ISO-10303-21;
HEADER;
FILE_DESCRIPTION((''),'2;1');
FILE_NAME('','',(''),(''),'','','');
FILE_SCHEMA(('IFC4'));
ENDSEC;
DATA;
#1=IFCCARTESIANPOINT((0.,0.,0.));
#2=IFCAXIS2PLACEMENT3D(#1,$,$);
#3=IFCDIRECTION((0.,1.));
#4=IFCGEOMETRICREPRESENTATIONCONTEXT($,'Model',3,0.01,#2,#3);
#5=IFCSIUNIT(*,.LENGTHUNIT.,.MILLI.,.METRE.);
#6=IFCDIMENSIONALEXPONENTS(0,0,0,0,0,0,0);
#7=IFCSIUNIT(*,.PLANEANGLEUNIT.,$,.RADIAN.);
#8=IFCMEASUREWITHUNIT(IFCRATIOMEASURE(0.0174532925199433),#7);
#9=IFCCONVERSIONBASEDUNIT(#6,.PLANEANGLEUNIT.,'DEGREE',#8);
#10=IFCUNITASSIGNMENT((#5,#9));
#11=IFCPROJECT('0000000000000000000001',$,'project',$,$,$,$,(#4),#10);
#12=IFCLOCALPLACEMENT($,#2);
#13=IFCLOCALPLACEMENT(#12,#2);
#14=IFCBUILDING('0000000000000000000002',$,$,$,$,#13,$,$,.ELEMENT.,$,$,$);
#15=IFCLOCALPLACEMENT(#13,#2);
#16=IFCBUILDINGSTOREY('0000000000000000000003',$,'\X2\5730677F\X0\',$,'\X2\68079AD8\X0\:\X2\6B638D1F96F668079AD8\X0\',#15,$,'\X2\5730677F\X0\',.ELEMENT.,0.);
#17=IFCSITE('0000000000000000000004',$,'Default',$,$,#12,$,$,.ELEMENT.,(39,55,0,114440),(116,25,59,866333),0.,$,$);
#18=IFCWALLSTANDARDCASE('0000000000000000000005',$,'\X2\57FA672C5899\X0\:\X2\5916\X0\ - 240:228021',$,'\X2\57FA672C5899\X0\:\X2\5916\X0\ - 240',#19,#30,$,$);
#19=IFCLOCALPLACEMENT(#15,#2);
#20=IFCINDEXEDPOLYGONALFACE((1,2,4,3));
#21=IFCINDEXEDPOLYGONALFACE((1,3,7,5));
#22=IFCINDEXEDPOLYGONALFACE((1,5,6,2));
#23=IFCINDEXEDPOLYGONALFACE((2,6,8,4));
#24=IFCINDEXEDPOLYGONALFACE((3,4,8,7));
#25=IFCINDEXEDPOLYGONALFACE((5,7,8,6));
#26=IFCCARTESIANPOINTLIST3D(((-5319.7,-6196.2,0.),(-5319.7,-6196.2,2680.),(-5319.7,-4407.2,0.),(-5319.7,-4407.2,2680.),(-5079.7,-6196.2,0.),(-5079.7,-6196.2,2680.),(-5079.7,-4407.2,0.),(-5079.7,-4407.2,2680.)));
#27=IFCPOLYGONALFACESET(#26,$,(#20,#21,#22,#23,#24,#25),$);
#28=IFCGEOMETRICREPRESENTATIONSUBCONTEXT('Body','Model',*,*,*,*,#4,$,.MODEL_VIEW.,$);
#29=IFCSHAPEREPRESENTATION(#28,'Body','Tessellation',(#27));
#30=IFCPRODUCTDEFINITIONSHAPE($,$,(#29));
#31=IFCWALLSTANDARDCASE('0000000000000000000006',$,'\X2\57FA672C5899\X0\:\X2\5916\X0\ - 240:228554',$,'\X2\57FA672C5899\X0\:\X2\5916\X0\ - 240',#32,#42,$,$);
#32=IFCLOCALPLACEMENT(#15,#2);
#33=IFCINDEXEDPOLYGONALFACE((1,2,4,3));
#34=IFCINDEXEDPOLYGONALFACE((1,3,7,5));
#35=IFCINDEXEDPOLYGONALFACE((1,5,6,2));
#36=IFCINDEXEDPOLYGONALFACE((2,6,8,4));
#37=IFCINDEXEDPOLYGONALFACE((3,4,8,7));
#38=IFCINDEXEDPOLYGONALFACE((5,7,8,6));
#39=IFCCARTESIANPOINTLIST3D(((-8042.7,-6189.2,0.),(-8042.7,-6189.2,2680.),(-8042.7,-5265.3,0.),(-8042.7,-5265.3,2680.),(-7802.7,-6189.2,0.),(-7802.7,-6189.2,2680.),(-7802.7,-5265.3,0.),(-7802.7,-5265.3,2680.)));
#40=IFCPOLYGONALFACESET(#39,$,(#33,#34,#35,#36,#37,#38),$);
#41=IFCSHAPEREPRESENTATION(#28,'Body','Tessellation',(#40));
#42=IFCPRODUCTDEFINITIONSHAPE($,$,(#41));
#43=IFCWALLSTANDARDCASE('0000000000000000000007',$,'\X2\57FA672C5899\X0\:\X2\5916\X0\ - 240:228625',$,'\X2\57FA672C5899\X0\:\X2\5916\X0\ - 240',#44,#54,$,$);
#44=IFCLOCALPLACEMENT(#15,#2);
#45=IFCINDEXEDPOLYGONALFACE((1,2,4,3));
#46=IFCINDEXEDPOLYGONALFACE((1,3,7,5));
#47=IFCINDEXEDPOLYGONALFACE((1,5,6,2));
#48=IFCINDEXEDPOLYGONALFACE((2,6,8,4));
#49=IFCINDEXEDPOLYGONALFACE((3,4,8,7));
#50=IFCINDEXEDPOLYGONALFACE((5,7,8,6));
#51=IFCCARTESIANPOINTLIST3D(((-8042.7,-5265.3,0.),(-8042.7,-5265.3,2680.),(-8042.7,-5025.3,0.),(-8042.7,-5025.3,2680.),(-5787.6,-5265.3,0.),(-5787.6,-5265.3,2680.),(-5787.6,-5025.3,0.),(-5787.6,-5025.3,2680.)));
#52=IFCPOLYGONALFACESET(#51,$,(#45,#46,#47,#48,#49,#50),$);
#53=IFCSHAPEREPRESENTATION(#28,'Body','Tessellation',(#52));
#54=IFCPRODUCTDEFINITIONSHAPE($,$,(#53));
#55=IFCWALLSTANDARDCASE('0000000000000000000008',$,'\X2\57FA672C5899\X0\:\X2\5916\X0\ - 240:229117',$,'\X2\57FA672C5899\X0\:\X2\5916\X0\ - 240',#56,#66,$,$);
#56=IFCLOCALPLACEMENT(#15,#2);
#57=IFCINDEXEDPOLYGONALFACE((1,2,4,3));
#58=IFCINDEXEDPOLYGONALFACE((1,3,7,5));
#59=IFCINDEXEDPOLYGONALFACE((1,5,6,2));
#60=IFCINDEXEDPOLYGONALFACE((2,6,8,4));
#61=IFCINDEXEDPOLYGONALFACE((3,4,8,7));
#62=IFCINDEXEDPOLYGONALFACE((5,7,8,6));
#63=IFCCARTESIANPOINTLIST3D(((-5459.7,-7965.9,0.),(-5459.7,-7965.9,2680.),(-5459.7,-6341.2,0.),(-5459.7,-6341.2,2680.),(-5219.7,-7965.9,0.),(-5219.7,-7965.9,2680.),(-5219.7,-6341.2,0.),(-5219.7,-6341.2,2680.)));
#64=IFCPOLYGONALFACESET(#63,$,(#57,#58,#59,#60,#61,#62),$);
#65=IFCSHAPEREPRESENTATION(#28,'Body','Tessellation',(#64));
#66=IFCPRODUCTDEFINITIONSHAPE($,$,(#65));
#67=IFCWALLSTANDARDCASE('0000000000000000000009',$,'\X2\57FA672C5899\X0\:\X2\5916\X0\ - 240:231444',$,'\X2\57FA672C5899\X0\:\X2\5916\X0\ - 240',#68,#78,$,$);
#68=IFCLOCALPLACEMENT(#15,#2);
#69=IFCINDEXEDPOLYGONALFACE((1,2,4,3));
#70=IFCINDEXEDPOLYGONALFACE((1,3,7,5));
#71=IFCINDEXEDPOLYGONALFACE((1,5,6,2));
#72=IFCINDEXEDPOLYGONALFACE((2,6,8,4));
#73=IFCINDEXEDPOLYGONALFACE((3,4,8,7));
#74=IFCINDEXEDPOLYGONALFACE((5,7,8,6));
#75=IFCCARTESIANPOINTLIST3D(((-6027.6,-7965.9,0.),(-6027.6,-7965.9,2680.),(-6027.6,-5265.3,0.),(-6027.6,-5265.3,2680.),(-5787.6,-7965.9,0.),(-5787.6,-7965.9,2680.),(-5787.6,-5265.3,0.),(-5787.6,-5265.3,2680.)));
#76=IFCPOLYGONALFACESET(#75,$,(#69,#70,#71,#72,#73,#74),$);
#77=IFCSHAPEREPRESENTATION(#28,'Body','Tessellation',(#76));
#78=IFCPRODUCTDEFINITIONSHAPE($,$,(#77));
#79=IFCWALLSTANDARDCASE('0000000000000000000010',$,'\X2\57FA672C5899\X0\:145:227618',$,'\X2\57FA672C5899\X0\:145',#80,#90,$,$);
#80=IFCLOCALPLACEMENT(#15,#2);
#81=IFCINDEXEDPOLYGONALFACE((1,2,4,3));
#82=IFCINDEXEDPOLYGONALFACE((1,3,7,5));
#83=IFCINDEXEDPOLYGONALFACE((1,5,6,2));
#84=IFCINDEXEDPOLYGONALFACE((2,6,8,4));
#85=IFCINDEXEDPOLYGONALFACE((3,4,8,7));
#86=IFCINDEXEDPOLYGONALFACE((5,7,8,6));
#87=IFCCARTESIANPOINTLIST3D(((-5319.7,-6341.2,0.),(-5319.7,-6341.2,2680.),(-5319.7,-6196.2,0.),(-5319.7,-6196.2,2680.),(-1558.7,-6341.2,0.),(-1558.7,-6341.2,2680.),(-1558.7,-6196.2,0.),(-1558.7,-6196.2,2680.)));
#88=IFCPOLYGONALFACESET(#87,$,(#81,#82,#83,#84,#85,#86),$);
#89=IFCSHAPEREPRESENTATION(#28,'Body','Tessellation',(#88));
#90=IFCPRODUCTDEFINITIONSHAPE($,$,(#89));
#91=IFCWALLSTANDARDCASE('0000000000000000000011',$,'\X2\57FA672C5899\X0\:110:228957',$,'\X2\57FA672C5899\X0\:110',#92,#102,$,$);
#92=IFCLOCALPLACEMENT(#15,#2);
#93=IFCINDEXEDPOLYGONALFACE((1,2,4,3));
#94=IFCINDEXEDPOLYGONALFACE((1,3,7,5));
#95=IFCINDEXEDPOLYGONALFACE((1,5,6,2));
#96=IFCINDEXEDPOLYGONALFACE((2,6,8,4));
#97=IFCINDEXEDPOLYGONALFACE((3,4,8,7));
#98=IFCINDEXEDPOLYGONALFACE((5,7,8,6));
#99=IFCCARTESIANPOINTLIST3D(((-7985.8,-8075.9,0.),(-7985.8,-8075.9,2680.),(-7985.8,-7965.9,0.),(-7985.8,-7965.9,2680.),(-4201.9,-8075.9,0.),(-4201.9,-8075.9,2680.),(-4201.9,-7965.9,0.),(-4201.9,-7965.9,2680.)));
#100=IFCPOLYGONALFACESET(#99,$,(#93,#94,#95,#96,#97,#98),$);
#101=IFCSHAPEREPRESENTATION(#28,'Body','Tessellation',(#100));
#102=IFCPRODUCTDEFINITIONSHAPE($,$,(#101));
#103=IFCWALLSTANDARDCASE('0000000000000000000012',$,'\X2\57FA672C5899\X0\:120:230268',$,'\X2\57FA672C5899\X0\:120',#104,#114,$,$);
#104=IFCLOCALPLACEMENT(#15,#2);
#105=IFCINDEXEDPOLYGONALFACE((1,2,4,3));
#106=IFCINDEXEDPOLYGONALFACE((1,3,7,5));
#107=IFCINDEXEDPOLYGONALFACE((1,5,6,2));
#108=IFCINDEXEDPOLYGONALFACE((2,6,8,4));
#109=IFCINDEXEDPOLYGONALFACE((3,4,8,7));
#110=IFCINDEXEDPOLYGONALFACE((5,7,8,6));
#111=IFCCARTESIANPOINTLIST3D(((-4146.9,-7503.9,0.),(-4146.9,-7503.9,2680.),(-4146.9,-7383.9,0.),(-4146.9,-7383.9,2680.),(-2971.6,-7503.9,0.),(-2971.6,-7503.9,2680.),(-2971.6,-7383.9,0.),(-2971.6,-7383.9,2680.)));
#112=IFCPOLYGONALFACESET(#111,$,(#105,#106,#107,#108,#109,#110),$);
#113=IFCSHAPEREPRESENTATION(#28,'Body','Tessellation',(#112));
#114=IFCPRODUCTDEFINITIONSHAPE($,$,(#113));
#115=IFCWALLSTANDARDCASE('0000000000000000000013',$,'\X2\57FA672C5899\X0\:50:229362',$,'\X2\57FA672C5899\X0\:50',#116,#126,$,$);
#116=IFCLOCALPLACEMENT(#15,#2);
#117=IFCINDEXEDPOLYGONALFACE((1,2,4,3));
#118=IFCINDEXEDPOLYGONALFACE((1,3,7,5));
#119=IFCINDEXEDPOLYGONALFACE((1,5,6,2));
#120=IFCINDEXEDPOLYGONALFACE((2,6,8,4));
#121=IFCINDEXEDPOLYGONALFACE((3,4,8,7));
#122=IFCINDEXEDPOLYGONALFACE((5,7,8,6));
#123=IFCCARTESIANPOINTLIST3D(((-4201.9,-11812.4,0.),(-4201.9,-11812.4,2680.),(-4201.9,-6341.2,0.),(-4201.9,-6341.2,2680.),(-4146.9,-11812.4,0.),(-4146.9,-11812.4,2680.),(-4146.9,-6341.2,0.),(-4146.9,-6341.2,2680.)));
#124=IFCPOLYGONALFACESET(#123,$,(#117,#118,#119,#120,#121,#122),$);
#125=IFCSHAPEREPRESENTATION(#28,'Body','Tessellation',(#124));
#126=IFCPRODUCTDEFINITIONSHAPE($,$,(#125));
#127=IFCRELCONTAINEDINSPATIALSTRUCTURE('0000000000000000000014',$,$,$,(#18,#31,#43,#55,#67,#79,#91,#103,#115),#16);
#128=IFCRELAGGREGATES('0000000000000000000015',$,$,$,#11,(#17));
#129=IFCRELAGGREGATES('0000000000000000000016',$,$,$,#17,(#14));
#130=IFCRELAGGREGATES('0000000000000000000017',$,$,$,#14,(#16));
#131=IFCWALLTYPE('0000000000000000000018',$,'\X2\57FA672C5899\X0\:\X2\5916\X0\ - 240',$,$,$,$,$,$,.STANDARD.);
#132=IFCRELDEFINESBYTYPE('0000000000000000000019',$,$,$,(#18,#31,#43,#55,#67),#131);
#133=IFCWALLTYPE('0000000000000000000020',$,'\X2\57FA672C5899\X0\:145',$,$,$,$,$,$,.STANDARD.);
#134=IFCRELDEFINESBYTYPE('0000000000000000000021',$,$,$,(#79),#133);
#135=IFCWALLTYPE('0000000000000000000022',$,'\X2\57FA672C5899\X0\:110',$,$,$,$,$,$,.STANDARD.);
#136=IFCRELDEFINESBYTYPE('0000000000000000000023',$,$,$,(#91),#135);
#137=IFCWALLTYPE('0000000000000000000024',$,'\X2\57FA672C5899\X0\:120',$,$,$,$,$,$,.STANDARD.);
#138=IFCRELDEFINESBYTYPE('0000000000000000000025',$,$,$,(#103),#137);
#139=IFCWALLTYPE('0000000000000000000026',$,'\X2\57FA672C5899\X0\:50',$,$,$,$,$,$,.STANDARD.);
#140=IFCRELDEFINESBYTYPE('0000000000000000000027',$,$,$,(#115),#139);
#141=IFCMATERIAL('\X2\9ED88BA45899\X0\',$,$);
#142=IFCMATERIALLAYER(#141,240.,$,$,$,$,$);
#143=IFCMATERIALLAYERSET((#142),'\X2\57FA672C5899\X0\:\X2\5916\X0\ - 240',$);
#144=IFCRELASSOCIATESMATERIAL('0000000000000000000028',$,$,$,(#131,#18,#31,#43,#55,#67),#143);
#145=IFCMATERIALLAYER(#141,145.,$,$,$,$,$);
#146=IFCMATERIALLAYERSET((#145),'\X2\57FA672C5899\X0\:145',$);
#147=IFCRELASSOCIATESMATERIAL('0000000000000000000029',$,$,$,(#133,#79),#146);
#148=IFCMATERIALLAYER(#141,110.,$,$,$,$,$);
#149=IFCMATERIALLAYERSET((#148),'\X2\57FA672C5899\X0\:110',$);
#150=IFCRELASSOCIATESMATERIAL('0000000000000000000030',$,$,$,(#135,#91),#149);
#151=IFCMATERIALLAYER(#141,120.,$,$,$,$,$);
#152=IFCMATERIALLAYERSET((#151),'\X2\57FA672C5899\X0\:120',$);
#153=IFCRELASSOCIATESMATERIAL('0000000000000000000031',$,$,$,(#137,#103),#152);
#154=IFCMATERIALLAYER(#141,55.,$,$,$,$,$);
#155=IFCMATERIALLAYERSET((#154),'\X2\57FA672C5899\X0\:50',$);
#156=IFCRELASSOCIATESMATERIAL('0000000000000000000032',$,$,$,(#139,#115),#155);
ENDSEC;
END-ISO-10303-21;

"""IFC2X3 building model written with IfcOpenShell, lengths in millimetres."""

from ifc_helpers import new_model, entity, si_unit, converted_unit, direction, frame, frame_2d, origin, place, context, subcontext, project, spatial, rectangle, extrude, material, layer, layer_set, layer_usage, type_object, element, save


model = new_model("IFC2X3")

# Units and contexts
model_context = context("Model", 3, precision=0.01, world=origin(), true_north=direction((0.0, 1.0)))
body_context = subcontext(model_context, "Body", "Model", "MODEL_VIEW")
ifc_project = project(units=[si_unit("LENGTHUNIT", "METRE", prefix="MILLI"), converted_unit("PLANEANGLEUNIT", "DEGREE", entity("IfcRatioMeasure", 0.0174532925199433), si_unit("PLANEANGLEUNIT", "RADIAN"), dimensions=[0, 0, 0, 0, 0, 0, 0])], contexts=[model_context])

# Site, building, storey
site_placement = place(None, origin())
site = spatial("IfcSite", under=ifc_project, at=site_placement, Name="Default", CompositionType="ELEMENT", RefLatitude=(39, 55, 0, 114440), RefLongitude=(116, 25, 59, 866333), RefElevation=0.0)
building_placement = place(site_placement, origin())
building = spatial("IfcBuilding", under=site, at=building_placement, CompositionType="ELEMENT")
storey_placement = place(building_placement, origin())
storey = spatial("IfcBuildingStorey", under=building, at=storey_placement, Name="地板", ObjectType="标高:正负零标高", LongName="地板", CompositionType="ELEMENT", Elevation=0.0)

# Shared definitions
ifc_material_1 = material(Name="默认墙")
ifc_layer_1 = layer(ifc_material_1, 240.0)
ifc_layer_set_1 = layer_set([ifc_layer_1], Name="基本墙:外 - 240")
wall_type_1 = type_object("IfcWallType", Name="基本墙:外 - 240", PredefinedType="STANDARD", material=ifc_layer_set_1)

# Wall
ifc_layer_usage_1 = layer_usage(ifc_layer_set_1, "AXIS2", "NEGATIVE", 120.0)
wall_1_placement = place(storey_placement, frame((-5199.7, -4407.2, 0.0), z_axis=(0.0, 0.0, 1.0), x_axis=(0.0, -1.0, 0.0)))
element("IfcWallStandardCase", 1, at=wall_1_placement, inside=storey, type_object=wall_type_1, material=ifc_layer_usage_1, Name="基本墙:外 - 240:228021", ObjectType="基本墙:外 - 240", context=body_context, shape_type="SweptSolid", body=[
    extrude(rectangle(XDim=1789.0, YDim=240.0, at=frame_2d((894.5, 0.0), x_axis=(-1.0, 0.0))), origin(), (0.0, 0.0, 1.0), 2680.0),
])

# Walls
ifc_layer_usage_2 = layer_usage(ifc_layer_set_1, "AXIS2", "NEGATIVE", 120.0)
wall_2_placement = place(storey_placement, frame((-7922.7, -5265.3, 0.0), z_axis=(0.0, 0.0, 1.0), x_axis=(0.0, -1.0, 0.0)))
element("IfcWallStandardCase", 2, at=wall_2_placement, inside=storey, type_object=wall_type_1, material=ifc_layer_usage_2, Name="基本墙:外 - 240:228554", ObjectType="基本墙:外 - 240", context=body_context, shape_type="SweptSolid", body=[
    extrude(rectangle(XDim=923.9, YDim=240.0, at=frame_2d((461.9, 0.0), x_axis=(-1.0, 0.0))), origin(), (0.0, 0.0, 1.0), 2680.0),
])
ifc_layer_usage_3 = layer_usage(ifc_layer_set_1, "AXIS2", "NEGATIVE", 120.0)
wall_3_placement = place(storey_placement, frame((-8042.7, -5145.3, 0.0)))
element("IfcWallStandardCase", 3, at=wall_3_placement, inside=storey, type_object=wall_type_1, material=ifc_layer_usage_3, Name="基本墙:外 - 240:228625", ObjectType="基本墙:外 - 240", context=body_context, shape_type="SweptSolid", body=[
    extrude(rectangle(XDim=2255.1, YDim=240.0, at=frame_2d((1127.5, 0.0), x_axis=(-1.0, 0.0))), origin(), (0.0, 0.0, 1.0), 2680.0),
])
ifc_layer_usage_4 = layer_usage(ifc_layer_set_1, "AXIS2", "NEGATIVE", 120.0)
wall_4_placement = place(storey_placement, frame((-5339.7, -6341.2, 0.0), z_axis=(0.0, 0.0, 1.0), x_axis=(0.0, -1.0, 0.0)))
element("IfcWallStandardCase", 4, at=wall_4_placement, inside=storey, type_object=wall_type_1, material=ifc_layer_usage_4, Name="基本墙:外 - 240:229117", ObjectType="基本墙:外 - 240", context=body_context, shape_type="SweptSolid", body=[
    extrude(rectangle(XDim=1624.7, YDim=240.0, at=frame_2d((812.3, 0.0), x_axis=(-1.0, 0.0))), origin(), (0.0, 0.0, 1.0), 2680.0),
])
ifc_layer_usage_5 = layer_usage(ifc_layer_set_1, "AXIS2", "NEGATIVE", 120.0)
wall_5_placement = place(storey_placement, frame((-5907.6, -5265.3, 0.0), z_axis=(0.0, 0.0, 1.0), x_axis=(0.0, -1.0, 0.0)))
element("IfcWallStandardCase", 5, at=wall_5_placement, inside=storey, type_object=wall_type_1, material=ifc_layer_usage_5, Name="基本墙:外 - 240:231444", ObjectType="基本墙:外 - 240", context=body_context, shape_type="SweptSolid", body=[
    extrude(rectangle(XDim=2700.5, YDim=240.0, at=frame_2d((1350.3, 0.0), x_axis=(-1.0, 0.0))), origin(), (0.0, 0.0, 1.0), 2680.0),
])
ifc_layer_2 = layer(ifc_material_1, 145.0)
ifc_layer_set_2 = layer_set([ifc_layer_2], Name="基本墙:145")
ifc_layer_usage_6 = layer_usage(ifc_layer_set_2, "AXIS2", "NEGATIVE", 72.5)
wall_type_2 = type_object("IfcWallType", Name="基本墙:145", PredefinedType="STANDARD", material=ifc_layer_set_2)
wall_6_placement = place(storey_placement, frame((-5319.7, -6268.7, 0.0)))
element("IfcWallStandardCase", 6, at=wall_6_placement, inside=storey, type_object=wall_type_2, material=ifc_layer_usage_6, Name="基本墙:145:227618", ObjectType="基本墙:145", context=body_context, shape_type="SweptSolid", body=[
    extrude(rectangle(XDim=3761.0, YDim=145.0, at=frame_2d((1880.5, 0.0), x_axis=(-1.0, 0.0))), origin(), (0.0, 0.0, 1.0), 2680.0),
])
ifc_layer_3 = layer(ifc_material_1, 110.0)
ifc_layer_set_3 = layer_set([ifc_layer_3], Name="基本墙:110")
ifc_layer_usage_7 = layer_usage(ifc_layer_set_3, "AXIS2", "NEGATIVE", 55.0)
wall_type_3 = type_object("IfcWallType", Name="基本墙:110", PredefinedType="STANDARD", material=ifc_layer_set_3)
wall_7_placement = place(storey_placement, frame((-7985.8, -8020.9, 0.0)))
element("IfcWallStandardCase", 7, at=wall_7_placement, inside=storey, type_object=wall_type_3, material=ifc_layer_usage_7, Name="基本墙:110:228957", ObjectType="基本墙:110", context=body_context, shape_type="SweptSolid", body=[
    extrude(rectangle(XDim=3783.9, YDim=110.0, at=frame_2d((1891.9, 0.0), x_axis=(-1.0, 0.0))), origin(), (0.0, 0.0, 1.0), 2680.0),
])
ifc_layer_4 = layer(ifc_material_1, 120.0)
ifc_layer_set_4 = layer_set([ifc_layer_4], Name="基本墙:120")
ifc_layer_usage_8 = layer_usage(ifc_layer_set_4, "AXIS2", "NEGATIVE", 60.0)
wall_type_4 = type_object("IfcWallType", Name="基本墙:120", PredefinedType="STANDARD", material=ifc_layer_set_4)
wall_8_placement = place(storey_placement, frame((-4146.9, -7443.9, 0.0)))
element("IfcWallStandardCase", 8, at=wall_8_placement, inside=storey, type_object=wall_type_4, material=ifc_layer_usage_8, Name="基本墙:120:230268", ObjectType="基本墙:120", context=body_context, shape_type="SweptSolid", body=[
    extrude(rectangle(XDim=1175.3, YDim=120.0, at=frame_2d((587.7, 0.0), x_axis=(-1.0, 0.0))), origin(), (0.0, 0.0, 1.0), 2680.0),
])
ifc_layer_5 = layer(ifc_material_1, 55.0)
ifc_layer_set_5 = layer_set([ifc_layer_5], Name="基本墙:50")
ifc_layer_usage_9 = layer_usage(ifc_layer_set_5, "AXIS2", "NEGATIVE", 27.5)
wall_type_5 = type_object("IfcWallType", Name="基本墙:50", PredefinedType="STANDARD", material=ifc_layer_set_5)
wall_9_placement = place(storey_placement, frame((-4174.4, -11812.4, 0.0), z_axis=(0.0, 0.0, 1.0), x_axis=(0.0, 1.0, 0.0)))
element("IfcWallStandardCase", 9, at=wall_9_placement, inside=storey, type_object=wall_type_5, material=ifc_layer_usage_9, Name="基本墙:50:229362", ObjectType="基本墙:50", context=body_context, shape_type="SweptSolid", body=[
    extrude(rectangle(XDim=5471.2, YDim=55.0, at=frame_2d((2735.6, 0.0), x_axis=(-1.0, 0.0))), origin(), (0.0, 0.0, 1.0), 2680.0),
])

save(model, "model.ifc")
